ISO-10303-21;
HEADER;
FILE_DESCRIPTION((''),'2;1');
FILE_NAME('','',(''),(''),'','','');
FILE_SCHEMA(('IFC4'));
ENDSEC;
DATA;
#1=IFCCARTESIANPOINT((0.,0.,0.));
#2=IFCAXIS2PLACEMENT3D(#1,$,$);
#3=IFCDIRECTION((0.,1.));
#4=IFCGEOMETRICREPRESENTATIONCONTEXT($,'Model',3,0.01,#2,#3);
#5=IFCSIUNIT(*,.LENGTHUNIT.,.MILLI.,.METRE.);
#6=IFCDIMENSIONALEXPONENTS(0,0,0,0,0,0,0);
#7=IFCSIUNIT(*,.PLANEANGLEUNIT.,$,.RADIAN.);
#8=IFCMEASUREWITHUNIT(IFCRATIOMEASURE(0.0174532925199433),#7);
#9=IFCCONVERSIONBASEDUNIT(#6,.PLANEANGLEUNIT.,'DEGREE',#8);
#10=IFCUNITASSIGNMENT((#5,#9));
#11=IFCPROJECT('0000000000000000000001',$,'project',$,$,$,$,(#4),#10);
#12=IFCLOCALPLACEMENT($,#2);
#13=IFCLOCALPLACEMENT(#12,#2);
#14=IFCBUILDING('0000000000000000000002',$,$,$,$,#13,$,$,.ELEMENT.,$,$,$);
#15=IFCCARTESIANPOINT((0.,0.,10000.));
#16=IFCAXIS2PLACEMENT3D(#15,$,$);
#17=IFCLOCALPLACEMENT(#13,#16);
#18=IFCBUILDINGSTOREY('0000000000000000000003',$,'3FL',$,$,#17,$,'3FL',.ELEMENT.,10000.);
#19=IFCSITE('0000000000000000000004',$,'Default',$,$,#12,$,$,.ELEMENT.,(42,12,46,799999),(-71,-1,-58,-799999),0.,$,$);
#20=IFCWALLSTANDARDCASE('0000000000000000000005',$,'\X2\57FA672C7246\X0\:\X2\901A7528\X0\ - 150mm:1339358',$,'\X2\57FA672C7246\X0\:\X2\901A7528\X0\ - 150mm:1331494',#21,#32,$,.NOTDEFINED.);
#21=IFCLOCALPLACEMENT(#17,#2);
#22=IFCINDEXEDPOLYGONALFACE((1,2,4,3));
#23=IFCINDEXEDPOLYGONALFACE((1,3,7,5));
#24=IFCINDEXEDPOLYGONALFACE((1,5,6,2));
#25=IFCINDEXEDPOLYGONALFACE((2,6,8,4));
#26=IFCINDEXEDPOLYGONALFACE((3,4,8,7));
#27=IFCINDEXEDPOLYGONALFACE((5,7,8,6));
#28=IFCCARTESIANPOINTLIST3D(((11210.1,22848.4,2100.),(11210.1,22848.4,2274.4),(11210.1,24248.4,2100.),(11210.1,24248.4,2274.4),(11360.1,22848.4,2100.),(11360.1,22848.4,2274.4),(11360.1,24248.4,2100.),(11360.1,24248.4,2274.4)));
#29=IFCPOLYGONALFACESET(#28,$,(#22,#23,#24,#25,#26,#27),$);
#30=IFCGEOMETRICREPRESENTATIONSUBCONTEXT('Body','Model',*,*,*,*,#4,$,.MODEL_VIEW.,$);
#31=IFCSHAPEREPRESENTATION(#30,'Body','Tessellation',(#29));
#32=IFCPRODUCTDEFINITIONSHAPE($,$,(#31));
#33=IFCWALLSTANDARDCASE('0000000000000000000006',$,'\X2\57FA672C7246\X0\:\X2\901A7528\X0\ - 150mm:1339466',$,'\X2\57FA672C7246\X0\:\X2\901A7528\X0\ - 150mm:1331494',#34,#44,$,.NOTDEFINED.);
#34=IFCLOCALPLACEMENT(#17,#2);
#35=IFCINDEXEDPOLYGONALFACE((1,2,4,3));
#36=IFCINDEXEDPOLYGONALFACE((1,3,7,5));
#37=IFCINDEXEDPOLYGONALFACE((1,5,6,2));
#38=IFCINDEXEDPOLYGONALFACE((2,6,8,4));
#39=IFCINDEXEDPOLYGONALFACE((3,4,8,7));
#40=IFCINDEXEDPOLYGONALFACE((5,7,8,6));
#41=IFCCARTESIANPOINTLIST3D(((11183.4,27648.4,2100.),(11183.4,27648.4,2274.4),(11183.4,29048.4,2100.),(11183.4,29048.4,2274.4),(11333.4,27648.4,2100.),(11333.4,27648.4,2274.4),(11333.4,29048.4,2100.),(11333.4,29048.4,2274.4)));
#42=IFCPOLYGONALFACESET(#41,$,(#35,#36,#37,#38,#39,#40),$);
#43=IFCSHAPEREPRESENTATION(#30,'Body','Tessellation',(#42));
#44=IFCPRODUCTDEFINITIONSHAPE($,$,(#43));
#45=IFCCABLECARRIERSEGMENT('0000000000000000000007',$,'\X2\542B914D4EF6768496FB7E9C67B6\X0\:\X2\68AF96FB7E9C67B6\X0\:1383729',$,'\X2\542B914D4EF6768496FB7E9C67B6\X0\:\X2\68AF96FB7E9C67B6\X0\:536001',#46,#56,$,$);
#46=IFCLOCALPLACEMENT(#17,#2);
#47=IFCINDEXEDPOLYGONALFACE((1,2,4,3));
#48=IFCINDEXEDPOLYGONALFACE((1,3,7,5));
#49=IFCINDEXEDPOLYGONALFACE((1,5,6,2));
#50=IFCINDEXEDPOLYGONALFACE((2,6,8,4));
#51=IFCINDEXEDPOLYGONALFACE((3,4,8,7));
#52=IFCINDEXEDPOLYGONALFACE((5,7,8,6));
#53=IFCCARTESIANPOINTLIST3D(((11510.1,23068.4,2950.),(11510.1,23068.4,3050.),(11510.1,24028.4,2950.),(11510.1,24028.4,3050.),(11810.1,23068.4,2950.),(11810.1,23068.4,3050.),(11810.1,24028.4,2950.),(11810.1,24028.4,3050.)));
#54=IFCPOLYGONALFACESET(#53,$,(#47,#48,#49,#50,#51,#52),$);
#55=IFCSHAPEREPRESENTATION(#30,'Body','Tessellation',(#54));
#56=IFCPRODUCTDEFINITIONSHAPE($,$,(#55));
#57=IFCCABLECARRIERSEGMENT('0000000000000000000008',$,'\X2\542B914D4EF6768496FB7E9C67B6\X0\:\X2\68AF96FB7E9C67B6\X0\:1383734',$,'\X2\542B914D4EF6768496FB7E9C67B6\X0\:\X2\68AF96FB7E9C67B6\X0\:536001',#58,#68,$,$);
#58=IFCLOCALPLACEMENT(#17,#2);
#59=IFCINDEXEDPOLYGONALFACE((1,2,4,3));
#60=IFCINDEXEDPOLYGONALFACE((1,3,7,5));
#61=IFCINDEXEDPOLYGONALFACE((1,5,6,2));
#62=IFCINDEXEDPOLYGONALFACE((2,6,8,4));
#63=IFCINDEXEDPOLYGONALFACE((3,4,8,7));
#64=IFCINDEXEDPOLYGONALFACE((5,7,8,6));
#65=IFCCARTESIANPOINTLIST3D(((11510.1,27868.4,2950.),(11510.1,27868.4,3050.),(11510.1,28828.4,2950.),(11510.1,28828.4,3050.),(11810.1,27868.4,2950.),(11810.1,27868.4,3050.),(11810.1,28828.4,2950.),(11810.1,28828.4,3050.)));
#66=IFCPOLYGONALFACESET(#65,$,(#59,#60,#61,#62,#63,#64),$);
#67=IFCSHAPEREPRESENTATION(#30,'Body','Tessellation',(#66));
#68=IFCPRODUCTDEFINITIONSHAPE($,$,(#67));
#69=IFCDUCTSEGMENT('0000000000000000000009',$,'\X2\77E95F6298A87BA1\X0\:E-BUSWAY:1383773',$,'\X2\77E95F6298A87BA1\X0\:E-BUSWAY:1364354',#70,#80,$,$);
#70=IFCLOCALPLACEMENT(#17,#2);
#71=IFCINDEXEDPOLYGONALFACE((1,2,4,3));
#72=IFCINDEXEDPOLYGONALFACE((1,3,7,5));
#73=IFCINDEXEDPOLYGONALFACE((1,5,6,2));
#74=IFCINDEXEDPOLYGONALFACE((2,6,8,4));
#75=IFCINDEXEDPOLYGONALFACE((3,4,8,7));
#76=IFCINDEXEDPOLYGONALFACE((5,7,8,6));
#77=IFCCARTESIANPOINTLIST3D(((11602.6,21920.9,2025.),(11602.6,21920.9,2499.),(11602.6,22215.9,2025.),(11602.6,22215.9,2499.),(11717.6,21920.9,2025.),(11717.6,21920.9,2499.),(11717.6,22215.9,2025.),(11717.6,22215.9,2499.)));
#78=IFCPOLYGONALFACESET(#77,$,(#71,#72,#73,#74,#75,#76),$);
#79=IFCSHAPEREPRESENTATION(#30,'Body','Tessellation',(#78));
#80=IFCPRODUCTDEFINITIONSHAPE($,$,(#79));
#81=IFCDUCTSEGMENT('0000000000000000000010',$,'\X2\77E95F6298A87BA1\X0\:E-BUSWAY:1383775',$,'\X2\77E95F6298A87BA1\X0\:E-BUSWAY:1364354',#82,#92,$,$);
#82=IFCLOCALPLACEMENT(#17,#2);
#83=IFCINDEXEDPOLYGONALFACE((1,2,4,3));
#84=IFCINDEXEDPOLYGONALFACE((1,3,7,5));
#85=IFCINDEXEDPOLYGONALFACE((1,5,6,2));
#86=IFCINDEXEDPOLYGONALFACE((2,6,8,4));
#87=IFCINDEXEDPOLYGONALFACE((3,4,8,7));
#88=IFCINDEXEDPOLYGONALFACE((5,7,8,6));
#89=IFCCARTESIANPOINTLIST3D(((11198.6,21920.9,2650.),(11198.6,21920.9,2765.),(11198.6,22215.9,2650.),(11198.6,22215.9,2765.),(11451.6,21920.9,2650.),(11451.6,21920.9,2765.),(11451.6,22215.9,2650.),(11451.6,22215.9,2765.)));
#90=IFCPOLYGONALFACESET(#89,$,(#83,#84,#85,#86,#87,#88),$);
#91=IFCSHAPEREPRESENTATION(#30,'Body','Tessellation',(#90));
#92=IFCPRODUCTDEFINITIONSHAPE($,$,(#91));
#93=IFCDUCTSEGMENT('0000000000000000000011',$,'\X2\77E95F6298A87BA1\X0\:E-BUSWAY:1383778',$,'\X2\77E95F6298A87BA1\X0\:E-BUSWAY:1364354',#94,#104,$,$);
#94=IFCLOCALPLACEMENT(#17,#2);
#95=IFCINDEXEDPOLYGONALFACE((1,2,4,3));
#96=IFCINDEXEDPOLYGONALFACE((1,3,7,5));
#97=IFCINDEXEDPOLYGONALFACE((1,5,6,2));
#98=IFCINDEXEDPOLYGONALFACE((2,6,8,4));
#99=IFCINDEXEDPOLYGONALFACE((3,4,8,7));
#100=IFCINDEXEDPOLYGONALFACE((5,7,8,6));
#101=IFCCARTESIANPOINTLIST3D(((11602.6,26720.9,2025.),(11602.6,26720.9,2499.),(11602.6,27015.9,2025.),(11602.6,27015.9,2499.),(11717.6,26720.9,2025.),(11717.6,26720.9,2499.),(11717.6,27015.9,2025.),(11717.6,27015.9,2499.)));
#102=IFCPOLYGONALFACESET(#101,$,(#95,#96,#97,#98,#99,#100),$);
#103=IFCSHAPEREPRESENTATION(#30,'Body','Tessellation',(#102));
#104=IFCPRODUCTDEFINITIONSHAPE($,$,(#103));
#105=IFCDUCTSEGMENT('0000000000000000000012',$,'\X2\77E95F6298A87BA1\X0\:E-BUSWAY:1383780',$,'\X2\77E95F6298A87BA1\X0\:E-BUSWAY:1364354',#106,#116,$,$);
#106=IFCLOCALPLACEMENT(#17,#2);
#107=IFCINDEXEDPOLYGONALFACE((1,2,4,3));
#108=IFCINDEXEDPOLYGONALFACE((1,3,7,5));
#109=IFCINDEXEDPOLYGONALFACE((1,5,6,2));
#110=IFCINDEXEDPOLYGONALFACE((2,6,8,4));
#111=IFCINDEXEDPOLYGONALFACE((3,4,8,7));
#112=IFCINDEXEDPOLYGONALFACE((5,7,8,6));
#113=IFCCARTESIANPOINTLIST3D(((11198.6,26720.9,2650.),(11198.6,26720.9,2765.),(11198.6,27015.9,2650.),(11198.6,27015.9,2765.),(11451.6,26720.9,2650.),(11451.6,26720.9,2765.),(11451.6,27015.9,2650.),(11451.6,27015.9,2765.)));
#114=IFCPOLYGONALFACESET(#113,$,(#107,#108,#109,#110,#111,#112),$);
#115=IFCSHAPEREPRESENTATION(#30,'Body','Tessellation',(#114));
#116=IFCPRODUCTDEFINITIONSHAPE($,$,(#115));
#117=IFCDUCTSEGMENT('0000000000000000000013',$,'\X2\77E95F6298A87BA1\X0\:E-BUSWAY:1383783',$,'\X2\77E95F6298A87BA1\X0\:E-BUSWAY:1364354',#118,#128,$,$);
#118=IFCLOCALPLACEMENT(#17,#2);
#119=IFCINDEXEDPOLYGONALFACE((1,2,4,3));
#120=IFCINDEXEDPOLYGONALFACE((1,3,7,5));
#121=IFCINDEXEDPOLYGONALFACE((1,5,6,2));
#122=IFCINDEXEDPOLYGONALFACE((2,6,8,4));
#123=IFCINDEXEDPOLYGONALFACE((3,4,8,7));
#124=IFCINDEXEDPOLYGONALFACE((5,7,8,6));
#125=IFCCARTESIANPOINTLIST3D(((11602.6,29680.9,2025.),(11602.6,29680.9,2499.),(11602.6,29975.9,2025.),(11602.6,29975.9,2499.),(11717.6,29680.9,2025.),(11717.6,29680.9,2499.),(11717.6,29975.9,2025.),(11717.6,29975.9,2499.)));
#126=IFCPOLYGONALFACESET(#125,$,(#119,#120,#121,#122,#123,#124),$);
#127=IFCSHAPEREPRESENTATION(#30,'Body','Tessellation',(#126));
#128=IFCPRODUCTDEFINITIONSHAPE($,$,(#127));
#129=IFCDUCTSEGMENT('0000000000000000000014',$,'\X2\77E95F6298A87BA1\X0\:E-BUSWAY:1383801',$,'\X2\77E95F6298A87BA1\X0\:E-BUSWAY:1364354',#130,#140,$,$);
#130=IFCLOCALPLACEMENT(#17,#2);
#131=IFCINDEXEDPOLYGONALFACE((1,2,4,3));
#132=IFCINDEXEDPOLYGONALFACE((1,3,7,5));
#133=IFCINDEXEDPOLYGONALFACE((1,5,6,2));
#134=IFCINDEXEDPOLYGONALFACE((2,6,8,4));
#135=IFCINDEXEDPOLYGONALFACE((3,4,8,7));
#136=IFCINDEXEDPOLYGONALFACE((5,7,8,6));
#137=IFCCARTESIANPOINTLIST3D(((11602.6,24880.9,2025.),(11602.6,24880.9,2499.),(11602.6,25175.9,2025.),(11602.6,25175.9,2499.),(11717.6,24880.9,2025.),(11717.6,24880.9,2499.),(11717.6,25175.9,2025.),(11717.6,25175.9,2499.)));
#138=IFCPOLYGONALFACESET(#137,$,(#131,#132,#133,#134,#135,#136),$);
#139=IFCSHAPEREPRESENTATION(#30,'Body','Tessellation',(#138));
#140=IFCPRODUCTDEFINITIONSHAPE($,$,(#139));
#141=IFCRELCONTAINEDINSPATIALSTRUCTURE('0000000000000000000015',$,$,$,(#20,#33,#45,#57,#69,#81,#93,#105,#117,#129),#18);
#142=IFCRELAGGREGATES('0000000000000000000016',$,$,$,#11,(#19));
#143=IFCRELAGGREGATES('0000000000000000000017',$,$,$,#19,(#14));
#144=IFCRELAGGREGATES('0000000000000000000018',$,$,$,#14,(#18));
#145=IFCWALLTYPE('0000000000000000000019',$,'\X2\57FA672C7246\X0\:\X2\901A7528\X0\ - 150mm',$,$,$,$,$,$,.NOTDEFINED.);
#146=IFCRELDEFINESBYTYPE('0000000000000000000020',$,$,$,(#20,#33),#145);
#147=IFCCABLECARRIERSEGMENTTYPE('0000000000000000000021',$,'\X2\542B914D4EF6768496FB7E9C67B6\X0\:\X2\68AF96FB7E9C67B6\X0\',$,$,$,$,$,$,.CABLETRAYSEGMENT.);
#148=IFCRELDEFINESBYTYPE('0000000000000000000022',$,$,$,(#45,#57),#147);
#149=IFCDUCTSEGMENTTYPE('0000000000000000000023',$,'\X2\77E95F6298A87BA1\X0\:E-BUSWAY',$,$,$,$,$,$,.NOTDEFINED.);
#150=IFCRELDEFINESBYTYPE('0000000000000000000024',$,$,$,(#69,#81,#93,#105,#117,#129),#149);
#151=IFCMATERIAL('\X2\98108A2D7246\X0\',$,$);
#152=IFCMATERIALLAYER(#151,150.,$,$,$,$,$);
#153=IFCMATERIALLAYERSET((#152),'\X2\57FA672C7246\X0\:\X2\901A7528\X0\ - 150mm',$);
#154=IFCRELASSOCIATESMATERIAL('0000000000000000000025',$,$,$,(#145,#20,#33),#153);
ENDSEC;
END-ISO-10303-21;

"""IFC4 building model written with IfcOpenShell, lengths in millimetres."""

from ifc_helpers import new_model, entity, si_unit, converted_unit, direction, frame, frame_2d, origin, origin_2d_with_axis, place, context, subcontext, project, spatial, rectangle, extrude, material, layer, layer_set, layer_usage, type_object, element, save


model = new_model("IFC4")

# Units and contexts
model_context = context("Model", 3, precision=0.01, world=origin(), true_north=direction((0.0, 1.0)))
body_context = subcontext(model_context, "Body", "Model", "MODEL_VIEW")
ifc_project = project(units=[si_unit("LENGTHUNIT", "METRE", prefix="MILLI"), converted_unit("PLANEANGLEUNIT", "DEGREE", entity("IfcRatioMeasure", 0.0174532925199433), si_unit("PLANEANGLEUNIT", "RADIAN"), dimensions=[0, 0, 0, 0, 0, 0, 0])], contexts=[model_context])

# Site, building, storey
site_placement = place(None, origin())
site = spatial("IfcSite", under=ifc_project, at=site_placement, Name="Default", CompositionType="ELEMENT", RefLatitude=(42, 12, 46, 799999), RefLongitude=(-71, -1, -58, -799999), RefElevation=0.0)
building_placement = place(site_placement, origin())
building = spatial("IfcBuilding", under=site, at=building_placement, CompositionType="ELEMENT")
storey_placement = place(building_placement, frame((0.0, 0.0, 10000.0)))
storey = spatial("IfcBuildingStorey", under=building, at=storey_placement, Name="3FL", LongName="3FL", CompositionType="ELEMENT", Elevation=10000.0)

# Walls, openings
ifc_material = material(Name="預設牆")
ifc_layer = layer(ifc_material, 150.0)
ifc_layer_set = layer_set([ifc_layer], Name="基本牆:通用 - 150mm")
ifc_layer_usage_1 = layer_usage(ifc_layer_set, "AXIS2", "NEGATIVE", 75.0)
wall_type = type_object("IfcWallType", Name="基本牆:通用 - 150mm", PredefinedType="NOTDEFINED", material=ifc_layer_set)
wall_1_placement = place(storey_placement, frame((11285.1, 24248.4, 2100.0), z_axis=(0.0, 0.0, 1.0), x_axis=(0.0, -1.0, 0.0)))
wall_1 = element("IfcWallStandardCase", 1, at=wall_1_placement, inside=storey, type_object=wall_type, material=ifc_layer_usage_1, Name="基本牆:通用 - 150mm:1339358", ObjectType="基本牆:通用 - 150mm:1331494", PredefinedType="NOTDEFINED", context=body_context, shape_type="SweptSolid", body=[
    extrude(rectangle(XDim=1400.0, YDim=150.0, at=frame_2d((700.0, 0.0), x_axis=(-1.0, 0.0))), origin(), (0.0, 0.0, 1.0), 174.4),
])
opening_1_placement = place(wall_1_placement, frame((1400.0, 75.0, -2100.0)))
element("IfcOpeningElement", 2, at=opening_1_placement, cuts=wall_1, ObjectType="Opening", PredefinedType="OPENING", context=body_context, shape_type="SweptSolid", body=[
    extrude(rectangle(XDim=2100.0, YDim=1400.0, at=frame_2d((1050.0, 700.0), x_axis=(1.0, 0.0))), frame((0.0, 0.0, 0.0), z_axis=(0.0, -1.0, 0.0), x_axis=(0.0, 0.0, 1.0)), (0.0, 0.0, 1.0), 150.0),
])
ifc_layer_usage_2 = layer_usage(ifc_layer_set, "AXIS2", "NEGATIVE", 75.0)
wall_2_placement = place(storey_placement, frame((11258.4, 29048.4, 2100.0), z_axis=(0.0, 0.0, 1.0), x_axis=(0.0, -1.0, 0.0)))
wall_2 = element("IfcWallStandardCase", 3, at=wall_2_placement, inside=storey, type_object=wall_type, material=ifc_layer_usage_2, Name="基本牆:通用 - 150mm:1339466", ObjectType="基本牆:通用 - 150mm:1331494", PredefinedType="NOTDEFINED", context=body_context, shape_type="SweptSolid", body=[
    extrude(rectangle(XDim=1400.0, YDim=150.0, at=frame_2d((700.0, 0.0), x_axis=(-1.0, 0.0))), origin(), (0.0, 0.0, 1.0), 174.4),
])
opening_2_placement = place(wall_2_placement, frame((1400.0, 75.0, -2100.0)))
element("IfcOpeningElement", 4, at=opening_2_placement, cuts=wall_2, ObjectType="Opening", PredefinedType="OPENING", context=body_context, shape_type="SweptSolid", body=[
    extrude(rectangle(XDim=2100.0, YDim=1400.0, at=frame_2d((1050.0, 700.0), x_axis=(1.0, 0.0))), frame((0.0, 0.0, 0.0), z_axis=(0.0, -1.0, 0.0), x_axis=(0.0, 0.0, 1.0)), (0.0, 0.0, 1.0), 150.0),
])

# Cable carrier segments
cable_carrier_segment_type = type_object("IfcCableCarrierSegmentType", Name="含配件的電纜架:梯電纜架", PredefinedType="CABLETRAYSEGMENT")
for number, where, name in (
    (5, (11510.1, 23068.4, 2950.0), "含配件的電纜架:梯電纜架:1383729"),
    (6, (11510.1, 27868.4, 2950.0), "含配件的電纜架:梯電纜架:1383734"),
):
    element("IfcCableCarrierSegment", number, at=place(storey_placement, frame(where)), inside=storey, type_object=cable_carrier_segment_type, Name=name, ObjectType="含配件的電纜架:梯電纜架:536001", context=body_context, shape_type="SweptSolid", body=[
        extrude(rectangle(XDim=960.0, YDim=300.0, at=origin_2d_with_axis()), frame((150.0, 480.0, 0.0), z_axis=(0.0, 0.0, 1.0), x_axis=(0.0, -1.0, 0.0)), (0.0, 0.0, 1.0), 100.0),
    ])

# Duct segments
duct_segment_type = type_object("IfcDuctSegmentType", Name="矩形風管:E-BUSWAY", PredefinedType="NOTDEFINED")
duct_segment_1_placement = place(storey_placement, frame((11602.6, 21920.9, 2025.0)))
element("IfcDuctSegment", 7, at=duct_segment_1_placement, inside=storey, type_object=duct_segment_type, Name="矩形風管:E-BUSWAY:1383773", ObjectType="矩形風管:E-BUSWAY:1364354", context=body_context, shape_type="SweptSolid", body=[
    extrude(rectangle(XDim=115.0, YDim=295.0, at=origin_2d_with_axis()), frame((57.5, 147.5, 0.0), z_axis=(0.0, 0.0, 1.0), x_axis=(-1.0, 0.0, 0.0)), (0.0, 0.0, 1.0), 474.0),
])
duct_segment_2_placement = place(storey_placement, frame((11198.6, 21920.9, 2650.0)))
element("IfcDuctSegment", 8, at=duct_segment_2_placement, inside=storey, type_object=duct_segment_type, Name="矩形風管:E-BUSWAY:1383775", ObjectType="矩形風管:E-BUSWAY:1364354", context=body_context, shape_type="SweptSolid", body=[
    extrude(rectangle(XDim=253.0, YDim=295.0, at=frame_2d((0.0, 0.0), x_axis=(1.0, 0.0))), frame((126.5, 147.5, 0.0)), (0.0, 0.0, 1.0), 115.0),
])
duct_segment_3_placement = place(storey_placement, frame((11602.6, 26720.9, 2025.0)))
element("IfcDuctSegment", 9, at=duct_segment_3_placement, inside=storey, type_object=duct_segment_type, Name="矩形風管:E-BUSWAY:1383778", ObjectType="矩形風管:E-BUSWAY:1364354", context=body_context, shape_type="SweptSolid", body=[
    extrude(rectangle(XDim=115.0, YDim=295.0, at=origin_2d_with_axis()), frame((57.5, 147.5, 0.0), z_axis=(0.0, 0.0, 1.0), x_axis=(-1.0, 0.0, 0.0)), (0.0, 0.0, 1.0), 474.0),
])
duct_segment_4_placement = place(storey_placement, frame((11198.6, 26720.9, 2650.0)))
element("IfcDuctSegment", 10, at=duct_segment_4_placement, inside=storey, type_object=duct_segment_type, Name="矩形風管:E-BUSWAY:1383780", ObjectType="矩形風管:E-BUSWAY:1364354", context=body_context, shape_type="SweptSolid", body=[
    extrude(rectangle(XDim=253.0, YDim=295.0, at=frame_2d((0.0, 0.0), x_axis=(1.0, 0.0))), frame((126.5, 147.5, 0.0)), (0.0, 0.0, 1.0), 115.0),
])
for number, where, name in (
    (11, (11602.6, 29680.9, 2025.0), "矩形風管:E-BUSWAY:1383783"),
    (12, (11602.6, 24880.9, 2025.0), "矩形風管:E-BUSWAY:1383801"),
):
    element("IfcDuctSegment", number, at=place(storey_placement, frame(where)), inside=storey, type_object=duct_segment_type, Name=name, ObjectType="矩形風管:E-BUSWAY:1364354", context=body_context, shape_type="SweptSolid", body=[
        extrude(rectangle(XDim=115.0, YDim=295.0, at=origin_2d_with_axis()), frame((57.5, 147.5, 0.0), z_axis=(0.0, 0.0, 1.0), x_axis=(-1.0, 0.0, 0.0)), (0.0, 0.0, 1.0), 474.0),
    ])

save(model, "model.ifc")
